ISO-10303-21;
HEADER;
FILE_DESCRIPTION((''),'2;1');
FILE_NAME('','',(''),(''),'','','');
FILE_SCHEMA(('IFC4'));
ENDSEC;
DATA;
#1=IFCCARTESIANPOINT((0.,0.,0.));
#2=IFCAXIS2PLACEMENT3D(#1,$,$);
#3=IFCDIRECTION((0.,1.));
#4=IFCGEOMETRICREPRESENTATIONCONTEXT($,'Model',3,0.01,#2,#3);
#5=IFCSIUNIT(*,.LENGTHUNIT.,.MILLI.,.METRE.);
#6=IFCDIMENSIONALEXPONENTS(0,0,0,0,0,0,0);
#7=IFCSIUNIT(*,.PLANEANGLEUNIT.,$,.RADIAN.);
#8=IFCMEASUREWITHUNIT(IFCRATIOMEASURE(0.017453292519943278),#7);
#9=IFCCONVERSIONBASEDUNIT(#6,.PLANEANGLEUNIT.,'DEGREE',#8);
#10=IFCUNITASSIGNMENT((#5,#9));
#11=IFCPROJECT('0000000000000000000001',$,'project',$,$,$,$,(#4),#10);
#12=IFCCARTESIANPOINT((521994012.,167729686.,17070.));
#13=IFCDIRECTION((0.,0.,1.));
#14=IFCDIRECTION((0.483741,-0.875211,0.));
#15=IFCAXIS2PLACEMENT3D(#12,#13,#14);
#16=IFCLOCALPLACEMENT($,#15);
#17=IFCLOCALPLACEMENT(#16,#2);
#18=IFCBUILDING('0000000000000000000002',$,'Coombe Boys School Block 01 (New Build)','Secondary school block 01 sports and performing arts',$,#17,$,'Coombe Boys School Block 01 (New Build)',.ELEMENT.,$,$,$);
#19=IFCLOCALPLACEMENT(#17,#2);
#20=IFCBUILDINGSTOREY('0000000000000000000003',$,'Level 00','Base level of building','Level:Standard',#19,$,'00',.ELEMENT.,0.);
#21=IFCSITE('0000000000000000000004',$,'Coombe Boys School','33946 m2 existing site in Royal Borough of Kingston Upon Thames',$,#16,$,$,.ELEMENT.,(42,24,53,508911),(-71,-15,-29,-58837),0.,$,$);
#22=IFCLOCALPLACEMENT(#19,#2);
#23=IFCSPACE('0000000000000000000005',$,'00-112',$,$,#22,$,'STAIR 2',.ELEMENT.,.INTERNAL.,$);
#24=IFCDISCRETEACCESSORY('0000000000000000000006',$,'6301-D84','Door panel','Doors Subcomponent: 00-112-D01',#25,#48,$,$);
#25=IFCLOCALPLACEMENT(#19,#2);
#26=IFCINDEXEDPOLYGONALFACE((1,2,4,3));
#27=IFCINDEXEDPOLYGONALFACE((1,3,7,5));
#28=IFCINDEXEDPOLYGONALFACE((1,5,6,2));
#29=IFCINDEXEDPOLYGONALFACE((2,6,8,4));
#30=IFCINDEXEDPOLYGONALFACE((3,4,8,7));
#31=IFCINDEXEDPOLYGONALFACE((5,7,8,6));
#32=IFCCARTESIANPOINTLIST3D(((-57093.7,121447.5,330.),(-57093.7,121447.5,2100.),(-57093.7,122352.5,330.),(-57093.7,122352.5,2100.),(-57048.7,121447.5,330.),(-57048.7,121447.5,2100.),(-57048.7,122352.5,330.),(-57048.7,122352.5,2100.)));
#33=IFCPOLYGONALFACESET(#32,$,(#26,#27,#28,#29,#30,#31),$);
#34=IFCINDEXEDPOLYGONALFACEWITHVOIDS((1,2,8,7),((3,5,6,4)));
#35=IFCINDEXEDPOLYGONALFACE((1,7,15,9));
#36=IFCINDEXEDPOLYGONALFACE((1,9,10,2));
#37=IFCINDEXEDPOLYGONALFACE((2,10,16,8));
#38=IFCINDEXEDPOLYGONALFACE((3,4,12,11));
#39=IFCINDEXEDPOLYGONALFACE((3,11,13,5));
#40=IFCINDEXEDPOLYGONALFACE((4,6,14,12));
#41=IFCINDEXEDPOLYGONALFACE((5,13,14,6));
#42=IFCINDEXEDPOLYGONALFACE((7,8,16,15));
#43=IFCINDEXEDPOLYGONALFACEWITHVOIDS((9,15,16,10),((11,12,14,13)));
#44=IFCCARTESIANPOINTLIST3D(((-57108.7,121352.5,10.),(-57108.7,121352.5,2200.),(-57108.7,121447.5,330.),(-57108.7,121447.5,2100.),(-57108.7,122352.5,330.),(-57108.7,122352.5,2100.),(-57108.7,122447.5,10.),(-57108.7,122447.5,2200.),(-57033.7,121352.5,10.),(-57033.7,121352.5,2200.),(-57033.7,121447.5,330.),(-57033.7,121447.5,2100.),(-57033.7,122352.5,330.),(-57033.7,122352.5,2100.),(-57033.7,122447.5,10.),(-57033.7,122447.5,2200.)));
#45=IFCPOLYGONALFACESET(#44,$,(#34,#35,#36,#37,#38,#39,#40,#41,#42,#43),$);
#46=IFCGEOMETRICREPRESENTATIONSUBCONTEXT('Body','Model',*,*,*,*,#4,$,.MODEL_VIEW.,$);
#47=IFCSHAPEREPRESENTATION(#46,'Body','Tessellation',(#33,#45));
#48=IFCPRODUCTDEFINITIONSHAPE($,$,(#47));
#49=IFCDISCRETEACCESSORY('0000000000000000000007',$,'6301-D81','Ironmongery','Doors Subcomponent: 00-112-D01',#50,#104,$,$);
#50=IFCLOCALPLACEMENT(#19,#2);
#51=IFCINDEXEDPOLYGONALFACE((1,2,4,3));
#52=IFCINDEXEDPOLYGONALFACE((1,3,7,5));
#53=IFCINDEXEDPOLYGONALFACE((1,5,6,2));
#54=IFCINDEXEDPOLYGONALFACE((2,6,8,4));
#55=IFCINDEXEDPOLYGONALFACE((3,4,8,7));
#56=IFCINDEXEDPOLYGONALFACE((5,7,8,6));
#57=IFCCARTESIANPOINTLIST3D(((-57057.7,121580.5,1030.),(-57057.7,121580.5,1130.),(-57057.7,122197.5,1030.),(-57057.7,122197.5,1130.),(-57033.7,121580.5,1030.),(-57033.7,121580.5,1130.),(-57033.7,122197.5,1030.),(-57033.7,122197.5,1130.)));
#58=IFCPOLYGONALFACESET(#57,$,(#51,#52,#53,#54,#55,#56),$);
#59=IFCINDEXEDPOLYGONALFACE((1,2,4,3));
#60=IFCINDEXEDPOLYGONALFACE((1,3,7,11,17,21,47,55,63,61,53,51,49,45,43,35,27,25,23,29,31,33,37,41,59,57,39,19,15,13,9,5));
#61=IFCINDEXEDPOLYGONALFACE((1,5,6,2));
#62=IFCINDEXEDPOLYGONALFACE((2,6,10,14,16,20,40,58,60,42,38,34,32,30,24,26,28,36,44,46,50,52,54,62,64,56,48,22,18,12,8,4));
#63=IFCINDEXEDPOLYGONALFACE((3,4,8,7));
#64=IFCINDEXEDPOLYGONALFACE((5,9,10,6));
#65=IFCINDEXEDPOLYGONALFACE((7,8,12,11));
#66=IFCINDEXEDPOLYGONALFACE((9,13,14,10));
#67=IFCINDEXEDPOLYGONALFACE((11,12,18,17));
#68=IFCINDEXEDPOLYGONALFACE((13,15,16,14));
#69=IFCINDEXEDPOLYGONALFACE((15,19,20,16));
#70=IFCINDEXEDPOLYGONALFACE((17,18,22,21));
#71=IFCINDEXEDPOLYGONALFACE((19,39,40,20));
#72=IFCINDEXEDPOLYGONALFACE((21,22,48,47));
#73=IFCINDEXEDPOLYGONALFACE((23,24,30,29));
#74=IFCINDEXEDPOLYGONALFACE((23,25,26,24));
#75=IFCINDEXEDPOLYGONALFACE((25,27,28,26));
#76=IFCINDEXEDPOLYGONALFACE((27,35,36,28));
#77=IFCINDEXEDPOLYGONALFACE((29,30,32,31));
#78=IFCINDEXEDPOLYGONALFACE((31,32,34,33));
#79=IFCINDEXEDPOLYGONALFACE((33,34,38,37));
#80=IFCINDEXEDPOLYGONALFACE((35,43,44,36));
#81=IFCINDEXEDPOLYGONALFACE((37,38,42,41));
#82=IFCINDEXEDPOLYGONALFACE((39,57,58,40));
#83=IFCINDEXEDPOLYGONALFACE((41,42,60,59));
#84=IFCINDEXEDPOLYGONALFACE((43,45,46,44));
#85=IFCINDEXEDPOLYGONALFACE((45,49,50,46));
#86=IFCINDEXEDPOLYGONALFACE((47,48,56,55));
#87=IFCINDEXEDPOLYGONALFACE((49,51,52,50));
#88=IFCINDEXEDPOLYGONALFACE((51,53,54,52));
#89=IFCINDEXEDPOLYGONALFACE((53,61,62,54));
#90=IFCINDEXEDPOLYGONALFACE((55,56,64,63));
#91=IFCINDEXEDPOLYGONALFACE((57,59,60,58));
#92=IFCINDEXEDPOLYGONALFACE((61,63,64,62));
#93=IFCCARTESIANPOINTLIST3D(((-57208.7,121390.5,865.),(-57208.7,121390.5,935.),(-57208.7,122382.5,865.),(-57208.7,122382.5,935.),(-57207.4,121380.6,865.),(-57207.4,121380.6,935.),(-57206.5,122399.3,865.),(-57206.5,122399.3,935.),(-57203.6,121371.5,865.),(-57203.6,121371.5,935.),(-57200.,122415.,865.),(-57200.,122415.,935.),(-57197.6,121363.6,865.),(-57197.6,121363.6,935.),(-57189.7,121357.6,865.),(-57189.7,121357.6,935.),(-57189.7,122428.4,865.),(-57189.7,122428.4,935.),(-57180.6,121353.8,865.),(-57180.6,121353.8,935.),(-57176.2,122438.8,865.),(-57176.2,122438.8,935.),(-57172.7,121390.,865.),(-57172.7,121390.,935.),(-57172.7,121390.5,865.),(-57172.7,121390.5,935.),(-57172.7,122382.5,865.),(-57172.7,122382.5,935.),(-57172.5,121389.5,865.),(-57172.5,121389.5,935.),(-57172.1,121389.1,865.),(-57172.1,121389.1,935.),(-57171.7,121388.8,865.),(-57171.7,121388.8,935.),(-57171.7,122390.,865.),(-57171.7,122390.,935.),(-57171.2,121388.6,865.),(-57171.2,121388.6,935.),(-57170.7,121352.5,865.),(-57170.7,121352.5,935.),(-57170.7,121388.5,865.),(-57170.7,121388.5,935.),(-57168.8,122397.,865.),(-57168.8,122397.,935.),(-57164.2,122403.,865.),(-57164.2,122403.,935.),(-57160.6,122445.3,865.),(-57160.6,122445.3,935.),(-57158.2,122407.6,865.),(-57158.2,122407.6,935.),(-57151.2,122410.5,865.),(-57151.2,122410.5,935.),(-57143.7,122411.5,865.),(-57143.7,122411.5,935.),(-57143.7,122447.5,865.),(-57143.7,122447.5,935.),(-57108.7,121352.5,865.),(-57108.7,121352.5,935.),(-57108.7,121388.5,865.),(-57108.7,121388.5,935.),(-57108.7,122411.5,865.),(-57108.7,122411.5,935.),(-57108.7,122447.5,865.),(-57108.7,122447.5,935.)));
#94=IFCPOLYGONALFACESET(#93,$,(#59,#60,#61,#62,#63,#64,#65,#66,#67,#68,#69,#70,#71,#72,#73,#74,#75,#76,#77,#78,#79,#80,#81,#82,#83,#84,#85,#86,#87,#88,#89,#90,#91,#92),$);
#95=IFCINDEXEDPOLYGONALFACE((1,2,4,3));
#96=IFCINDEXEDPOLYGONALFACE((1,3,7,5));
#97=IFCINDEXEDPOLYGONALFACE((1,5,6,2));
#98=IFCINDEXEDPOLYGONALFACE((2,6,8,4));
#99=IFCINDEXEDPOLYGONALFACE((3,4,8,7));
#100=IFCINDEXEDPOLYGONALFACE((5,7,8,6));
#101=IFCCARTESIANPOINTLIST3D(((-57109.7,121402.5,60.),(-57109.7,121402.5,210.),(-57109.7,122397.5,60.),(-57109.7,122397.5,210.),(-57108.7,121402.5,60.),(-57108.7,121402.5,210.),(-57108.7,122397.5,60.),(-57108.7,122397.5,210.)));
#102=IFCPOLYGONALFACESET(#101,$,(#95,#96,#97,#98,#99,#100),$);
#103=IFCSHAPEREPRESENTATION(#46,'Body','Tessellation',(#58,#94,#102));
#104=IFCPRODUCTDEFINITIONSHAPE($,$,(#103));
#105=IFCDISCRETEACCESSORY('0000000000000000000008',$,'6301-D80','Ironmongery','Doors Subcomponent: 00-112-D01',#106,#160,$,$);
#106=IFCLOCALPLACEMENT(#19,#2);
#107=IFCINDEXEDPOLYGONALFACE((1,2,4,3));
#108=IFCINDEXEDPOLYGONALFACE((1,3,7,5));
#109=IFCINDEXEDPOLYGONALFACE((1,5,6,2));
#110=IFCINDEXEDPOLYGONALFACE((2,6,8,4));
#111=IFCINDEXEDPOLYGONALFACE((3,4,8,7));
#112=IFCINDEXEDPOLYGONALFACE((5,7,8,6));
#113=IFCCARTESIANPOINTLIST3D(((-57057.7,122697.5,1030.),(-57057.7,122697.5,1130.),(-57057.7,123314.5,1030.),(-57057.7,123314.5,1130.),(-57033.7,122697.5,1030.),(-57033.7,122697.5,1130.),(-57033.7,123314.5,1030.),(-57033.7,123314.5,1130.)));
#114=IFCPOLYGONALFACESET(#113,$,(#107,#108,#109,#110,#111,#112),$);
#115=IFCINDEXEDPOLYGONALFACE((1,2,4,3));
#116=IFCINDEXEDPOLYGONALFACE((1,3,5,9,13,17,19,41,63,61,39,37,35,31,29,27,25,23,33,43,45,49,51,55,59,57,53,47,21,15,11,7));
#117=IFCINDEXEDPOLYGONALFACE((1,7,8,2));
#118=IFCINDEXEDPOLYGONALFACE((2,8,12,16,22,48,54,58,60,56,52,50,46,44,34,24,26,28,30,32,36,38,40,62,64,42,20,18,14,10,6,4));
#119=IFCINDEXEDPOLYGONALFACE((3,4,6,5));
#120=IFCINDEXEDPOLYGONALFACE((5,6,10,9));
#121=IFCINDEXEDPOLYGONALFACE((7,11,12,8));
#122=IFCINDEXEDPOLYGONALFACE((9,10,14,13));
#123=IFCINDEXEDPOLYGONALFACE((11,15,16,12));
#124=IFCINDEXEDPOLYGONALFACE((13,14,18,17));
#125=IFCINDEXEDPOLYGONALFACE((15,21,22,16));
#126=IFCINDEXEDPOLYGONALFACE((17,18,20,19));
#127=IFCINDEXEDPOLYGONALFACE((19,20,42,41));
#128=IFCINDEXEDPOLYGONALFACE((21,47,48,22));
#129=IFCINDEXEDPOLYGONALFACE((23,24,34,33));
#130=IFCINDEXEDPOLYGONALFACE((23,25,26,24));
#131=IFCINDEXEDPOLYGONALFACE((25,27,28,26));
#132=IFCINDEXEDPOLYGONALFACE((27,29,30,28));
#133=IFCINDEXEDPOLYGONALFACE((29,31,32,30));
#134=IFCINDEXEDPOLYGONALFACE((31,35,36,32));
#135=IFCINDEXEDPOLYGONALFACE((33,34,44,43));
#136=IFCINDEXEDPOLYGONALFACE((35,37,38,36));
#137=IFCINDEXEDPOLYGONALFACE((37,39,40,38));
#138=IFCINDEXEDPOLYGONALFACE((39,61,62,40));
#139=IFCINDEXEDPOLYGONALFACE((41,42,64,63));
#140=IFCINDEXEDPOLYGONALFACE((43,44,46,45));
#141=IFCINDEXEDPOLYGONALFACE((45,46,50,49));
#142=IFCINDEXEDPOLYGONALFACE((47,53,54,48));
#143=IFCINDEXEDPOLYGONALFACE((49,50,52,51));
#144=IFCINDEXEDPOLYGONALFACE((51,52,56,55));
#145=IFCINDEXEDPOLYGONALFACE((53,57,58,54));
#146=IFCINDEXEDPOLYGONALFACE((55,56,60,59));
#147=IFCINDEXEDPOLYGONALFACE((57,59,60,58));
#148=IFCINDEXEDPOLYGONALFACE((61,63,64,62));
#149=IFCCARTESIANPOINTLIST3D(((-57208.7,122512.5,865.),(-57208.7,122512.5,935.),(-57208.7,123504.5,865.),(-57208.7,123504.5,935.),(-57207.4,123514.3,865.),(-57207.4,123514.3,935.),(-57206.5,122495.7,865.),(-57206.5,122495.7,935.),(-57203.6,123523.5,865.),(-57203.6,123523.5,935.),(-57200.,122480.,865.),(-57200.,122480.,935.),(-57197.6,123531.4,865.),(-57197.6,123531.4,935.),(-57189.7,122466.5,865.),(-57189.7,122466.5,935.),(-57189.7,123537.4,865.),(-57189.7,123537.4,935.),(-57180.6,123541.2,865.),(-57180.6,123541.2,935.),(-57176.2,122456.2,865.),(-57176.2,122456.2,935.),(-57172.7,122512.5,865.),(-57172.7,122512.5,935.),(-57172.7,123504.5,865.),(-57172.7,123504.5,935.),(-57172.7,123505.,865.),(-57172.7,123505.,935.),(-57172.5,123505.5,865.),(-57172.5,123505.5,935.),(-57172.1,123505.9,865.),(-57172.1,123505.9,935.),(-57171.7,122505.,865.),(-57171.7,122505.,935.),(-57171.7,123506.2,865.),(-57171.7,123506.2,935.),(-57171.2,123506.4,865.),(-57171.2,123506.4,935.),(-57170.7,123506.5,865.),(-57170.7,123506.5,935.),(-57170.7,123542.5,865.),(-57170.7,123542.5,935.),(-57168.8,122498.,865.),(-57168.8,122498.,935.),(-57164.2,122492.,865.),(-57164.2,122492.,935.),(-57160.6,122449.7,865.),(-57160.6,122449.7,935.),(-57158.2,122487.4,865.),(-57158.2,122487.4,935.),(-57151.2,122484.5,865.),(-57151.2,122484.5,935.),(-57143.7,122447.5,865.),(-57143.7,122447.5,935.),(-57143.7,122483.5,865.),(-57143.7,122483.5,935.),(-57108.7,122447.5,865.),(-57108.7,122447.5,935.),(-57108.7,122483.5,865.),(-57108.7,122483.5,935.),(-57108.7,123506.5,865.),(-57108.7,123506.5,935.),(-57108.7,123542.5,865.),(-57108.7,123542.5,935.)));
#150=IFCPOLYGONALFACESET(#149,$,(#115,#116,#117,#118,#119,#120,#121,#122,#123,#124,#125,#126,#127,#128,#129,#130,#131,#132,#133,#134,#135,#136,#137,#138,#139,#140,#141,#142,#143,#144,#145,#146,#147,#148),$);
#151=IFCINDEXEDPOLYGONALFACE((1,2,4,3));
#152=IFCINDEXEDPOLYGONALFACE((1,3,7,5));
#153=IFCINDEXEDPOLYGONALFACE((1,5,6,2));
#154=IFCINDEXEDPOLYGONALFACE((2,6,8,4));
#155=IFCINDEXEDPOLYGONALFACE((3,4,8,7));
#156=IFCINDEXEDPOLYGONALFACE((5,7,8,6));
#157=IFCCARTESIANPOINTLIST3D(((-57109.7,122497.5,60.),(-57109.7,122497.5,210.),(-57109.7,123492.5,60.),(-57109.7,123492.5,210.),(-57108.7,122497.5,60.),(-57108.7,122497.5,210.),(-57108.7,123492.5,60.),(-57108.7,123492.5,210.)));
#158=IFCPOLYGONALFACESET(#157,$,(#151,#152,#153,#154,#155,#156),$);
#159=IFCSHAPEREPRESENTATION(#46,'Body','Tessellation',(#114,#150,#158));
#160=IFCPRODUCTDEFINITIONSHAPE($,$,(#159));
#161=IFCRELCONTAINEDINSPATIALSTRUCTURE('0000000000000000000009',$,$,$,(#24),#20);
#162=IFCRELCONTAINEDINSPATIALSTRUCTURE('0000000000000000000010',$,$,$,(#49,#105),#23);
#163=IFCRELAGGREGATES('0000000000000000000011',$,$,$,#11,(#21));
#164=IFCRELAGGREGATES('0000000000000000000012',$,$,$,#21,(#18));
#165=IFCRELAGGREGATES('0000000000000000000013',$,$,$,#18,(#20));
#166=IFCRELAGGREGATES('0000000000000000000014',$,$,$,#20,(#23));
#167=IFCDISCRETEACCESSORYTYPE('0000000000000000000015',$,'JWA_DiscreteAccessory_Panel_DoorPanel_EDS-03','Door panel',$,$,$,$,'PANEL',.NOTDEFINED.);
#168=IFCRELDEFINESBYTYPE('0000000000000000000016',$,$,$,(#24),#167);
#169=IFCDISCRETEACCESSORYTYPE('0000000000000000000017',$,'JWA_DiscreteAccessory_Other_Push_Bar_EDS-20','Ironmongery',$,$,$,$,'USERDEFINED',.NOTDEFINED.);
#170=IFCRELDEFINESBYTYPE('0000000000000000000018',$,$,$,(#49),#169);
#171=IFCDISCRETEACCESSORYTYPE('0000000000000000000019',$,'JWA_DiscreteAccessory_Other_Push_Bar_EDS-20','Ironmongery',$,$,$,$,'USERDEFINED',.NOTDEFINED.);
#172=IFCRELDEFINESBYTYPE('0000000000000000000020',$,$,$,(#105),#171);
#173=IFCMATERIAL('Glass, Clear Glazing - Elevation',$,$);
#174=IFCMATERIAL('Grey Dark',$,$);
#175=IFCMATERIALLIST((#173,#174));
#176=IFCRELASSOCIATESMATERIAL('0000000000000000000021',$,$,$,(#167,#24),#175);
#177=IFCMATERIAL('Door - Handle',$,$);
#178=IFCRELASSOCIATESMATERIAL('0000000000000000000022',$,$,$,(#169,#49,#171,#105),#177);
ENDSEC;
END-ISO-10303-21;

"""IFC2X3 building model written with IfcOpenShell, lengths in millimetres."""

from ifc_helpers import new_model, entity, si_unit, converted_unit, direction, frame, frame_2d, origin, origin_2d_with_axis, place, context, subcontext, project, spatial, polyline, circle_curve, parameter, trimmed, segment, composite_curve, rectangle, outline, extrude, source, transform, mapped, material, material_list, type_object, type_shapes, element, save


model = new_model("IFC2X3")

# Units and contexts
model_context = context("Model", 3, precision=0.01, world=origin(), true_north=direction((0.0, 1.0)))
body_context = subcontext(model_context, "Body", "Model", "MODEL_VIEW")
ifc_project = project(units=[si_unit("LENGTHUNIT", "METRE", prefix="MILLI"), converted_unit("PLANEANGLEUNIT", "DEGREE", entity("IfcRatioMeasure", 0.017453292519943278), si_unit("PLANEANGLEUNIT", "RADIAN"), dimensions=[0, 0, 0, 0, 0, 0, 0])], contexts=[model_context])

# Site, building, storey
site_placement = place(None, frame((521994012.0, 167729686.0, 17070.0), z_axis=(0.0, 0.0, 1.0), x_axis=(0.483741, -0.875211, 0.0)))
site = spatial("IfcSite", under=ifc_project, at=site_placement, Name="Coombe Boys School", Description="33946 m2 existing site in Royal Borough of Kingston Upon Thames", CompositionType="ELEMENT", RefLatitude=(42, 24, 53, 508911), RefLongitude=(-71, -15, -29, -58837), RefElevation=0.0)
building_placement = place(site_placement, origin())
building = spatial("IfcBuilding", under=site, at=building_placement, Name="Coombe Boys School Block 01 (New Build)", Description="Secondary school block 01 sports and performing arts", LongName="Coombe Boys School Block 01 (New Build)", CompositionType="ELEMENT")
storey_placement = place(building_placement, origin())
storey = spatial("IfcBuildingStorey", under=building, at=storey_placement, Name="Level 00", Description="Base level of building", ObjectType="Level:Standard", LongName="00", CompositionType="ELEMENT", Elevation=0.0)

# Shared definitions
ifc_material_1 = material(Name="Glass, Clear Glazing - Elevation")

# Discrete accessory
ifc_material_2 = material(Name="Grey Dark")
ifc_material_list_1 = material_list([ifc_material_1, ifc_material_2])
discrete_accessory_type_1 = type_object("IfcDiscreteAccessoryType", Name="JWA_DiscreteAccessory_Panel_DoorPanel_EDS-03", Description="Door panel", ElementType="PANEL", material=ifc_material_list_1)
shared_shape_1 = source(origin(), body_context, "Body", "SweptSolid", [
    extrude(rectangle(XDim=45.0, YDim=905.0, at=origin_2d_with_axis()), frame((0.0, 37.5, 330.0), z_axis=(0.0, 0.0, 1.0), x_axis=(0.0, 1.0, 0.0)), (0.0, 0.0, 1.0), 1770.0),
    extrude(outline(polyline([(-1095.0, -547.5), (1095.0, -547.5), (1095.0, 547.5), (-1095.0, 547.5), (-1095.0, -547.5)]), holes=[polyline([(-995.0, -452.5), (-995.0, 452.5), (775.0, 452.5), (775.0, -452.5), (-995.0, -452.5)])]), frame((0.0, 0.0, 1105.0), z_axis=(0.0, 1.0, 0.0), x_axis=(0.0, 0.0, -1.0)), (0.0, 0.0, 1.0), 75.0),
])
type_shapes(discrete_accessory_type_1, [shared_shape_1])
discrete_accessory_1_placement = place(storey_placement, frame((-57108.7, 121900.0, 0.0), z_axis=(0.0, 0.0, 1.0), x_axis=(0.0, -1.0, 0.0)))
element("IfcDiscreteAccessory", 1, at=discrete_accessory_1_placement, inside=storey, type_object=discrete_accessory_type_1, material=ifc_material_list_1, Name="6301-D84", Description="Door panel", ObjectType="Doors Subcomponent: 00-112-D01", context=body_context, shape_type="MappedRepresentation", body=[
    mapped(shared_shape_1, transform((0.0, 0.0, 0.0), scale=1.0)),
])

# Shared definitions
space_placement = place(storey_placement, origin())
space = spatial("IfcSpace", under=storey, at=space_placement, Name="00-112", LongName="STAIR 2", CompositionType="ELEMENT", InteriorOrExteriorSpace="INTERNAL")

# Discrete accessories
ifc_material_3 = material(Name="Door - Handle")
discrete_accessory_type_2 = type_object("IfcDiscreteAccessoryType", Name="JWA_DiscreteAccessory_Other_Push_Bar_EDS-20", Description="Ironmongery", ElementType="USERDEFINED", material=ifc_material_3)
shared_shape_2 = source(origin(), body_context, "Body", "SweptSolid", [
    extrude(rectangle(XDim=24.0, YDim=617.0, at=frame_2d((0.0, 0.0), x_axis=(1.0, 0.0))), frame((11.0, 63.0, 1030.0), z_axis=(0.0, 0.0, 1.0), x_axis=(0.0, -1.0, 0.0)), (0.0, 0.0, 1.0), 100.0),
    extrude(outline(composite_curve([segment(polyline([(-43.5, -552.0), (-8.5, -552.0)]), True, "CONTINUOUS"), segment(trimmed(circle_curve(frame_2d((-8.5, -487.0), x_axis=(0.0, -1.0)), 65.0), [parameter(0.0)], [parameter(90.0)], True, "PARAMETER"), True, "CONTINUOUS"), segment(polyline([(56.5, -487.0), (56.5, 505.0)]), True, "CONTINUOUS"), segment(trimmed(circle_curve(frame_2d((18.5, 505.0), x_axis=(1.0, 0.0)), 38.0), [parameter(0.0)], [parameter(90.0)], True, "PARAMETER"), True, "CONTINUOUS"), segment(polyline([(18.5, 543.0), (-43.5, 543.0)]), True, "CONTINUOUS"), segment(polyline([(-43.5, 543.0), (-43.5, 507.0)]), True, "CONTINUOUS"), segment(polyline([(-43.5, 507.0), (18.5, 507.0)]), True, "CONTINUOUS"), segment(trimmed(circle_curve(frame_2d((18.5, 505.0), x_axis=(1.0, 0.0)), 2.0), [parameter(0.0)], [parameter(90.0)], True, "PARAMETER"), False, "CONTINUOUS"), segment(polyline([(20.5, 505.0), (20.5, -487.0)]), True, "CONTINUOUS"), segment(trimmed(circle_curve(frame_2d((-8.5, -487.0), x_axis=(0.0, -1.0)), 29.0), [parameter(0.0)], [parameter(90.0)], True, "PARAMETER"), False, "CONTINUOUS"), segment(polyline([(-8.5, -516.0), (-43.5, -516.0)]), True, "CONTINUOUS"), segment(polyline([(-43.5, -516.0), (-43.5, -552.0)]), True, "CONTINUOUS")], self_intersect=False)), frame((4.5, -43.5, 865.0), z_axis=(0.0, 0.0, 1.0), x_axis=(0.0, -1.0, 0.0)), (0.0, 0.0, 1.0), 70.0),
    extrude(rectangle(XDim=1.0, YDim=995.0, at=origin_2d_with_axis()), frame((0.0, -0.5, 60.0), z_axis=(0.0, 0.0, 1.0), x_axis=(0.0, 1.0, 0.0)), (0.0, 0.0, 1.0), 150.0),
])
type_shapes(discrete_accessory_type_2, [shared_shape_2])
discrete_accessory_2_placement = place(space_placement, frame((-57108.7, 121900.0, 0.0), z_axis=(0.0, 0.0, 1.0), x_axis=(0.0, -1.0, 0.0)))
element("IfcDiscreteAccessory", 2, at=discrete_accessory_2_placement, inside=space, type_object=discrete_accessory_type_2, material=ifc_material_3, Name="6301-D81", Description="Ironmongery", ObjectType="Doors Subcomponent: 00-112-D01", context=body_context, shape_type="MappedRepresentation", body=[
    mapped(shared_shape_2, transform((0.0, 0.0, 0.0), scale=1.0)),
])
discrete_accessory_type_3 = type_object("IfcDiscreteAccessoryType", Name="JWA_DiscreteAccessory_Other_Push_Bar_EDS-20", Description="Ironmongery", ElementType="USERDEFINED", material=ifc_material_3)
shared_shape_3 = source(origin(), body_context, "Body", "SweptSolid", [
    extrude(rectangle(XDim=617.0, YDim=24.0, at=frame_2d((0.0, 0.0), x_axis=(1.0, 0.0))), frame((11.0, -63.0, 1030.0)), (0.0, 0.0, 1.0), 100.0),
    extrude(outline(composite_curve([segment(polyline([(-552.0, -43.5), (-516.0, -43.5)]), True, "CONTINUOUS"), segment(polyline([(-516.0, -43.5), (-516.0, -8.5)]), True, "CONTINUOUS"), segment(trimmed(circle_curve(frame_2d((-487.0, -8.5), x_axis=(-1.0, 0.0)), 29.0), [parameter(270.0)], [parameter(0.0)], True, "PARAMETER"), False, "CONTINUOUS"), segment(polyline([(-487.0, 20.5), (505.0, 20.5)]), True, "CONTINUOUS"), segment(trimmed(circle_curve(frame_2d((505.0, 18.5), x_axis=(0.0, 1.0)), 2.0), [parameter(270.0)], [parameter(0.0)], True, "PARAMETER"), False, "CONTINUOUS"), segment(polyline([(507.0, 18.5), (507.0, -43.5)]), True, "CONTINUOUS"), segment(polyline([(507.0, -43.5), (543.0, -43.5)]), True, "CONTINUOUS"), segment(polyline([(543.0, -43.5), (543.0, 18.5)]), True, "CONTINUOUS"), segment(trimmed(circle_curve(frame_2d((505.0, 18.5), x_axis=(0.0, 1.0)), 38.0), [parameter(270.0)], [parameter(0.0)], True, "PARAMETER"), True, "CONTINUOUS"), segment(polyline([(505.0, 56.5), (-487.0, 56.5)]), True, "CONTINUOUS"), segment(trimmed(circle_curve(frame_2d((-487.0, -8.5), x_axis=(-1.0, 0.0)), 65.0), [parameter(270.0)], [parameter(0.0)], True, "PARAMETER"), True, "CONTINUOUS"), segment(polyline([(-552.0, -8.5), (-552.0, -43.5)]), True, "CONTINUOUS")], self_intersect=False)), frame((4.5, 43.5, 865.0)), (0.0, 0.0, 1.0), 70.0),
    extrude(rectangle(XDim=995.0, YDim=1.0, at=origin_2d_with_axis()), frame((0.0, 0.5, 60.0), z_axis=(0.0, 0.0, 1.0), x_axis=(-1.0, 0.0, 0.0)), (0.0, 0.0, 1.0), 150.0),
])
type_shapes(discrete_accessory_type_3, [shared_shape_3])
discrete_accessory_3_placement = place(space_placement, frame((-57108.7, 122995.0, 0.0), z_axis=(0.0, 0.0, 1.0), x_axis=(0.0, 1.0, 0.0)))
element("IfcDiscreteAccessory", 3, at=discrete_accessory_3_placement, inside=space, type_object=discrete_accessory_type_3, material=ifc_material_3, Name="6301-D80", Description="Ironmongery", ObjectType="Doors Subcomponent: 00-112-D01", context=body_context, shape_type="MappedRepresentation", body=[
    mapped(shared_shape_3, transform((0.0, 0.0, 0.0), scale=1.0)),
])

save(model, "model.ifc")
